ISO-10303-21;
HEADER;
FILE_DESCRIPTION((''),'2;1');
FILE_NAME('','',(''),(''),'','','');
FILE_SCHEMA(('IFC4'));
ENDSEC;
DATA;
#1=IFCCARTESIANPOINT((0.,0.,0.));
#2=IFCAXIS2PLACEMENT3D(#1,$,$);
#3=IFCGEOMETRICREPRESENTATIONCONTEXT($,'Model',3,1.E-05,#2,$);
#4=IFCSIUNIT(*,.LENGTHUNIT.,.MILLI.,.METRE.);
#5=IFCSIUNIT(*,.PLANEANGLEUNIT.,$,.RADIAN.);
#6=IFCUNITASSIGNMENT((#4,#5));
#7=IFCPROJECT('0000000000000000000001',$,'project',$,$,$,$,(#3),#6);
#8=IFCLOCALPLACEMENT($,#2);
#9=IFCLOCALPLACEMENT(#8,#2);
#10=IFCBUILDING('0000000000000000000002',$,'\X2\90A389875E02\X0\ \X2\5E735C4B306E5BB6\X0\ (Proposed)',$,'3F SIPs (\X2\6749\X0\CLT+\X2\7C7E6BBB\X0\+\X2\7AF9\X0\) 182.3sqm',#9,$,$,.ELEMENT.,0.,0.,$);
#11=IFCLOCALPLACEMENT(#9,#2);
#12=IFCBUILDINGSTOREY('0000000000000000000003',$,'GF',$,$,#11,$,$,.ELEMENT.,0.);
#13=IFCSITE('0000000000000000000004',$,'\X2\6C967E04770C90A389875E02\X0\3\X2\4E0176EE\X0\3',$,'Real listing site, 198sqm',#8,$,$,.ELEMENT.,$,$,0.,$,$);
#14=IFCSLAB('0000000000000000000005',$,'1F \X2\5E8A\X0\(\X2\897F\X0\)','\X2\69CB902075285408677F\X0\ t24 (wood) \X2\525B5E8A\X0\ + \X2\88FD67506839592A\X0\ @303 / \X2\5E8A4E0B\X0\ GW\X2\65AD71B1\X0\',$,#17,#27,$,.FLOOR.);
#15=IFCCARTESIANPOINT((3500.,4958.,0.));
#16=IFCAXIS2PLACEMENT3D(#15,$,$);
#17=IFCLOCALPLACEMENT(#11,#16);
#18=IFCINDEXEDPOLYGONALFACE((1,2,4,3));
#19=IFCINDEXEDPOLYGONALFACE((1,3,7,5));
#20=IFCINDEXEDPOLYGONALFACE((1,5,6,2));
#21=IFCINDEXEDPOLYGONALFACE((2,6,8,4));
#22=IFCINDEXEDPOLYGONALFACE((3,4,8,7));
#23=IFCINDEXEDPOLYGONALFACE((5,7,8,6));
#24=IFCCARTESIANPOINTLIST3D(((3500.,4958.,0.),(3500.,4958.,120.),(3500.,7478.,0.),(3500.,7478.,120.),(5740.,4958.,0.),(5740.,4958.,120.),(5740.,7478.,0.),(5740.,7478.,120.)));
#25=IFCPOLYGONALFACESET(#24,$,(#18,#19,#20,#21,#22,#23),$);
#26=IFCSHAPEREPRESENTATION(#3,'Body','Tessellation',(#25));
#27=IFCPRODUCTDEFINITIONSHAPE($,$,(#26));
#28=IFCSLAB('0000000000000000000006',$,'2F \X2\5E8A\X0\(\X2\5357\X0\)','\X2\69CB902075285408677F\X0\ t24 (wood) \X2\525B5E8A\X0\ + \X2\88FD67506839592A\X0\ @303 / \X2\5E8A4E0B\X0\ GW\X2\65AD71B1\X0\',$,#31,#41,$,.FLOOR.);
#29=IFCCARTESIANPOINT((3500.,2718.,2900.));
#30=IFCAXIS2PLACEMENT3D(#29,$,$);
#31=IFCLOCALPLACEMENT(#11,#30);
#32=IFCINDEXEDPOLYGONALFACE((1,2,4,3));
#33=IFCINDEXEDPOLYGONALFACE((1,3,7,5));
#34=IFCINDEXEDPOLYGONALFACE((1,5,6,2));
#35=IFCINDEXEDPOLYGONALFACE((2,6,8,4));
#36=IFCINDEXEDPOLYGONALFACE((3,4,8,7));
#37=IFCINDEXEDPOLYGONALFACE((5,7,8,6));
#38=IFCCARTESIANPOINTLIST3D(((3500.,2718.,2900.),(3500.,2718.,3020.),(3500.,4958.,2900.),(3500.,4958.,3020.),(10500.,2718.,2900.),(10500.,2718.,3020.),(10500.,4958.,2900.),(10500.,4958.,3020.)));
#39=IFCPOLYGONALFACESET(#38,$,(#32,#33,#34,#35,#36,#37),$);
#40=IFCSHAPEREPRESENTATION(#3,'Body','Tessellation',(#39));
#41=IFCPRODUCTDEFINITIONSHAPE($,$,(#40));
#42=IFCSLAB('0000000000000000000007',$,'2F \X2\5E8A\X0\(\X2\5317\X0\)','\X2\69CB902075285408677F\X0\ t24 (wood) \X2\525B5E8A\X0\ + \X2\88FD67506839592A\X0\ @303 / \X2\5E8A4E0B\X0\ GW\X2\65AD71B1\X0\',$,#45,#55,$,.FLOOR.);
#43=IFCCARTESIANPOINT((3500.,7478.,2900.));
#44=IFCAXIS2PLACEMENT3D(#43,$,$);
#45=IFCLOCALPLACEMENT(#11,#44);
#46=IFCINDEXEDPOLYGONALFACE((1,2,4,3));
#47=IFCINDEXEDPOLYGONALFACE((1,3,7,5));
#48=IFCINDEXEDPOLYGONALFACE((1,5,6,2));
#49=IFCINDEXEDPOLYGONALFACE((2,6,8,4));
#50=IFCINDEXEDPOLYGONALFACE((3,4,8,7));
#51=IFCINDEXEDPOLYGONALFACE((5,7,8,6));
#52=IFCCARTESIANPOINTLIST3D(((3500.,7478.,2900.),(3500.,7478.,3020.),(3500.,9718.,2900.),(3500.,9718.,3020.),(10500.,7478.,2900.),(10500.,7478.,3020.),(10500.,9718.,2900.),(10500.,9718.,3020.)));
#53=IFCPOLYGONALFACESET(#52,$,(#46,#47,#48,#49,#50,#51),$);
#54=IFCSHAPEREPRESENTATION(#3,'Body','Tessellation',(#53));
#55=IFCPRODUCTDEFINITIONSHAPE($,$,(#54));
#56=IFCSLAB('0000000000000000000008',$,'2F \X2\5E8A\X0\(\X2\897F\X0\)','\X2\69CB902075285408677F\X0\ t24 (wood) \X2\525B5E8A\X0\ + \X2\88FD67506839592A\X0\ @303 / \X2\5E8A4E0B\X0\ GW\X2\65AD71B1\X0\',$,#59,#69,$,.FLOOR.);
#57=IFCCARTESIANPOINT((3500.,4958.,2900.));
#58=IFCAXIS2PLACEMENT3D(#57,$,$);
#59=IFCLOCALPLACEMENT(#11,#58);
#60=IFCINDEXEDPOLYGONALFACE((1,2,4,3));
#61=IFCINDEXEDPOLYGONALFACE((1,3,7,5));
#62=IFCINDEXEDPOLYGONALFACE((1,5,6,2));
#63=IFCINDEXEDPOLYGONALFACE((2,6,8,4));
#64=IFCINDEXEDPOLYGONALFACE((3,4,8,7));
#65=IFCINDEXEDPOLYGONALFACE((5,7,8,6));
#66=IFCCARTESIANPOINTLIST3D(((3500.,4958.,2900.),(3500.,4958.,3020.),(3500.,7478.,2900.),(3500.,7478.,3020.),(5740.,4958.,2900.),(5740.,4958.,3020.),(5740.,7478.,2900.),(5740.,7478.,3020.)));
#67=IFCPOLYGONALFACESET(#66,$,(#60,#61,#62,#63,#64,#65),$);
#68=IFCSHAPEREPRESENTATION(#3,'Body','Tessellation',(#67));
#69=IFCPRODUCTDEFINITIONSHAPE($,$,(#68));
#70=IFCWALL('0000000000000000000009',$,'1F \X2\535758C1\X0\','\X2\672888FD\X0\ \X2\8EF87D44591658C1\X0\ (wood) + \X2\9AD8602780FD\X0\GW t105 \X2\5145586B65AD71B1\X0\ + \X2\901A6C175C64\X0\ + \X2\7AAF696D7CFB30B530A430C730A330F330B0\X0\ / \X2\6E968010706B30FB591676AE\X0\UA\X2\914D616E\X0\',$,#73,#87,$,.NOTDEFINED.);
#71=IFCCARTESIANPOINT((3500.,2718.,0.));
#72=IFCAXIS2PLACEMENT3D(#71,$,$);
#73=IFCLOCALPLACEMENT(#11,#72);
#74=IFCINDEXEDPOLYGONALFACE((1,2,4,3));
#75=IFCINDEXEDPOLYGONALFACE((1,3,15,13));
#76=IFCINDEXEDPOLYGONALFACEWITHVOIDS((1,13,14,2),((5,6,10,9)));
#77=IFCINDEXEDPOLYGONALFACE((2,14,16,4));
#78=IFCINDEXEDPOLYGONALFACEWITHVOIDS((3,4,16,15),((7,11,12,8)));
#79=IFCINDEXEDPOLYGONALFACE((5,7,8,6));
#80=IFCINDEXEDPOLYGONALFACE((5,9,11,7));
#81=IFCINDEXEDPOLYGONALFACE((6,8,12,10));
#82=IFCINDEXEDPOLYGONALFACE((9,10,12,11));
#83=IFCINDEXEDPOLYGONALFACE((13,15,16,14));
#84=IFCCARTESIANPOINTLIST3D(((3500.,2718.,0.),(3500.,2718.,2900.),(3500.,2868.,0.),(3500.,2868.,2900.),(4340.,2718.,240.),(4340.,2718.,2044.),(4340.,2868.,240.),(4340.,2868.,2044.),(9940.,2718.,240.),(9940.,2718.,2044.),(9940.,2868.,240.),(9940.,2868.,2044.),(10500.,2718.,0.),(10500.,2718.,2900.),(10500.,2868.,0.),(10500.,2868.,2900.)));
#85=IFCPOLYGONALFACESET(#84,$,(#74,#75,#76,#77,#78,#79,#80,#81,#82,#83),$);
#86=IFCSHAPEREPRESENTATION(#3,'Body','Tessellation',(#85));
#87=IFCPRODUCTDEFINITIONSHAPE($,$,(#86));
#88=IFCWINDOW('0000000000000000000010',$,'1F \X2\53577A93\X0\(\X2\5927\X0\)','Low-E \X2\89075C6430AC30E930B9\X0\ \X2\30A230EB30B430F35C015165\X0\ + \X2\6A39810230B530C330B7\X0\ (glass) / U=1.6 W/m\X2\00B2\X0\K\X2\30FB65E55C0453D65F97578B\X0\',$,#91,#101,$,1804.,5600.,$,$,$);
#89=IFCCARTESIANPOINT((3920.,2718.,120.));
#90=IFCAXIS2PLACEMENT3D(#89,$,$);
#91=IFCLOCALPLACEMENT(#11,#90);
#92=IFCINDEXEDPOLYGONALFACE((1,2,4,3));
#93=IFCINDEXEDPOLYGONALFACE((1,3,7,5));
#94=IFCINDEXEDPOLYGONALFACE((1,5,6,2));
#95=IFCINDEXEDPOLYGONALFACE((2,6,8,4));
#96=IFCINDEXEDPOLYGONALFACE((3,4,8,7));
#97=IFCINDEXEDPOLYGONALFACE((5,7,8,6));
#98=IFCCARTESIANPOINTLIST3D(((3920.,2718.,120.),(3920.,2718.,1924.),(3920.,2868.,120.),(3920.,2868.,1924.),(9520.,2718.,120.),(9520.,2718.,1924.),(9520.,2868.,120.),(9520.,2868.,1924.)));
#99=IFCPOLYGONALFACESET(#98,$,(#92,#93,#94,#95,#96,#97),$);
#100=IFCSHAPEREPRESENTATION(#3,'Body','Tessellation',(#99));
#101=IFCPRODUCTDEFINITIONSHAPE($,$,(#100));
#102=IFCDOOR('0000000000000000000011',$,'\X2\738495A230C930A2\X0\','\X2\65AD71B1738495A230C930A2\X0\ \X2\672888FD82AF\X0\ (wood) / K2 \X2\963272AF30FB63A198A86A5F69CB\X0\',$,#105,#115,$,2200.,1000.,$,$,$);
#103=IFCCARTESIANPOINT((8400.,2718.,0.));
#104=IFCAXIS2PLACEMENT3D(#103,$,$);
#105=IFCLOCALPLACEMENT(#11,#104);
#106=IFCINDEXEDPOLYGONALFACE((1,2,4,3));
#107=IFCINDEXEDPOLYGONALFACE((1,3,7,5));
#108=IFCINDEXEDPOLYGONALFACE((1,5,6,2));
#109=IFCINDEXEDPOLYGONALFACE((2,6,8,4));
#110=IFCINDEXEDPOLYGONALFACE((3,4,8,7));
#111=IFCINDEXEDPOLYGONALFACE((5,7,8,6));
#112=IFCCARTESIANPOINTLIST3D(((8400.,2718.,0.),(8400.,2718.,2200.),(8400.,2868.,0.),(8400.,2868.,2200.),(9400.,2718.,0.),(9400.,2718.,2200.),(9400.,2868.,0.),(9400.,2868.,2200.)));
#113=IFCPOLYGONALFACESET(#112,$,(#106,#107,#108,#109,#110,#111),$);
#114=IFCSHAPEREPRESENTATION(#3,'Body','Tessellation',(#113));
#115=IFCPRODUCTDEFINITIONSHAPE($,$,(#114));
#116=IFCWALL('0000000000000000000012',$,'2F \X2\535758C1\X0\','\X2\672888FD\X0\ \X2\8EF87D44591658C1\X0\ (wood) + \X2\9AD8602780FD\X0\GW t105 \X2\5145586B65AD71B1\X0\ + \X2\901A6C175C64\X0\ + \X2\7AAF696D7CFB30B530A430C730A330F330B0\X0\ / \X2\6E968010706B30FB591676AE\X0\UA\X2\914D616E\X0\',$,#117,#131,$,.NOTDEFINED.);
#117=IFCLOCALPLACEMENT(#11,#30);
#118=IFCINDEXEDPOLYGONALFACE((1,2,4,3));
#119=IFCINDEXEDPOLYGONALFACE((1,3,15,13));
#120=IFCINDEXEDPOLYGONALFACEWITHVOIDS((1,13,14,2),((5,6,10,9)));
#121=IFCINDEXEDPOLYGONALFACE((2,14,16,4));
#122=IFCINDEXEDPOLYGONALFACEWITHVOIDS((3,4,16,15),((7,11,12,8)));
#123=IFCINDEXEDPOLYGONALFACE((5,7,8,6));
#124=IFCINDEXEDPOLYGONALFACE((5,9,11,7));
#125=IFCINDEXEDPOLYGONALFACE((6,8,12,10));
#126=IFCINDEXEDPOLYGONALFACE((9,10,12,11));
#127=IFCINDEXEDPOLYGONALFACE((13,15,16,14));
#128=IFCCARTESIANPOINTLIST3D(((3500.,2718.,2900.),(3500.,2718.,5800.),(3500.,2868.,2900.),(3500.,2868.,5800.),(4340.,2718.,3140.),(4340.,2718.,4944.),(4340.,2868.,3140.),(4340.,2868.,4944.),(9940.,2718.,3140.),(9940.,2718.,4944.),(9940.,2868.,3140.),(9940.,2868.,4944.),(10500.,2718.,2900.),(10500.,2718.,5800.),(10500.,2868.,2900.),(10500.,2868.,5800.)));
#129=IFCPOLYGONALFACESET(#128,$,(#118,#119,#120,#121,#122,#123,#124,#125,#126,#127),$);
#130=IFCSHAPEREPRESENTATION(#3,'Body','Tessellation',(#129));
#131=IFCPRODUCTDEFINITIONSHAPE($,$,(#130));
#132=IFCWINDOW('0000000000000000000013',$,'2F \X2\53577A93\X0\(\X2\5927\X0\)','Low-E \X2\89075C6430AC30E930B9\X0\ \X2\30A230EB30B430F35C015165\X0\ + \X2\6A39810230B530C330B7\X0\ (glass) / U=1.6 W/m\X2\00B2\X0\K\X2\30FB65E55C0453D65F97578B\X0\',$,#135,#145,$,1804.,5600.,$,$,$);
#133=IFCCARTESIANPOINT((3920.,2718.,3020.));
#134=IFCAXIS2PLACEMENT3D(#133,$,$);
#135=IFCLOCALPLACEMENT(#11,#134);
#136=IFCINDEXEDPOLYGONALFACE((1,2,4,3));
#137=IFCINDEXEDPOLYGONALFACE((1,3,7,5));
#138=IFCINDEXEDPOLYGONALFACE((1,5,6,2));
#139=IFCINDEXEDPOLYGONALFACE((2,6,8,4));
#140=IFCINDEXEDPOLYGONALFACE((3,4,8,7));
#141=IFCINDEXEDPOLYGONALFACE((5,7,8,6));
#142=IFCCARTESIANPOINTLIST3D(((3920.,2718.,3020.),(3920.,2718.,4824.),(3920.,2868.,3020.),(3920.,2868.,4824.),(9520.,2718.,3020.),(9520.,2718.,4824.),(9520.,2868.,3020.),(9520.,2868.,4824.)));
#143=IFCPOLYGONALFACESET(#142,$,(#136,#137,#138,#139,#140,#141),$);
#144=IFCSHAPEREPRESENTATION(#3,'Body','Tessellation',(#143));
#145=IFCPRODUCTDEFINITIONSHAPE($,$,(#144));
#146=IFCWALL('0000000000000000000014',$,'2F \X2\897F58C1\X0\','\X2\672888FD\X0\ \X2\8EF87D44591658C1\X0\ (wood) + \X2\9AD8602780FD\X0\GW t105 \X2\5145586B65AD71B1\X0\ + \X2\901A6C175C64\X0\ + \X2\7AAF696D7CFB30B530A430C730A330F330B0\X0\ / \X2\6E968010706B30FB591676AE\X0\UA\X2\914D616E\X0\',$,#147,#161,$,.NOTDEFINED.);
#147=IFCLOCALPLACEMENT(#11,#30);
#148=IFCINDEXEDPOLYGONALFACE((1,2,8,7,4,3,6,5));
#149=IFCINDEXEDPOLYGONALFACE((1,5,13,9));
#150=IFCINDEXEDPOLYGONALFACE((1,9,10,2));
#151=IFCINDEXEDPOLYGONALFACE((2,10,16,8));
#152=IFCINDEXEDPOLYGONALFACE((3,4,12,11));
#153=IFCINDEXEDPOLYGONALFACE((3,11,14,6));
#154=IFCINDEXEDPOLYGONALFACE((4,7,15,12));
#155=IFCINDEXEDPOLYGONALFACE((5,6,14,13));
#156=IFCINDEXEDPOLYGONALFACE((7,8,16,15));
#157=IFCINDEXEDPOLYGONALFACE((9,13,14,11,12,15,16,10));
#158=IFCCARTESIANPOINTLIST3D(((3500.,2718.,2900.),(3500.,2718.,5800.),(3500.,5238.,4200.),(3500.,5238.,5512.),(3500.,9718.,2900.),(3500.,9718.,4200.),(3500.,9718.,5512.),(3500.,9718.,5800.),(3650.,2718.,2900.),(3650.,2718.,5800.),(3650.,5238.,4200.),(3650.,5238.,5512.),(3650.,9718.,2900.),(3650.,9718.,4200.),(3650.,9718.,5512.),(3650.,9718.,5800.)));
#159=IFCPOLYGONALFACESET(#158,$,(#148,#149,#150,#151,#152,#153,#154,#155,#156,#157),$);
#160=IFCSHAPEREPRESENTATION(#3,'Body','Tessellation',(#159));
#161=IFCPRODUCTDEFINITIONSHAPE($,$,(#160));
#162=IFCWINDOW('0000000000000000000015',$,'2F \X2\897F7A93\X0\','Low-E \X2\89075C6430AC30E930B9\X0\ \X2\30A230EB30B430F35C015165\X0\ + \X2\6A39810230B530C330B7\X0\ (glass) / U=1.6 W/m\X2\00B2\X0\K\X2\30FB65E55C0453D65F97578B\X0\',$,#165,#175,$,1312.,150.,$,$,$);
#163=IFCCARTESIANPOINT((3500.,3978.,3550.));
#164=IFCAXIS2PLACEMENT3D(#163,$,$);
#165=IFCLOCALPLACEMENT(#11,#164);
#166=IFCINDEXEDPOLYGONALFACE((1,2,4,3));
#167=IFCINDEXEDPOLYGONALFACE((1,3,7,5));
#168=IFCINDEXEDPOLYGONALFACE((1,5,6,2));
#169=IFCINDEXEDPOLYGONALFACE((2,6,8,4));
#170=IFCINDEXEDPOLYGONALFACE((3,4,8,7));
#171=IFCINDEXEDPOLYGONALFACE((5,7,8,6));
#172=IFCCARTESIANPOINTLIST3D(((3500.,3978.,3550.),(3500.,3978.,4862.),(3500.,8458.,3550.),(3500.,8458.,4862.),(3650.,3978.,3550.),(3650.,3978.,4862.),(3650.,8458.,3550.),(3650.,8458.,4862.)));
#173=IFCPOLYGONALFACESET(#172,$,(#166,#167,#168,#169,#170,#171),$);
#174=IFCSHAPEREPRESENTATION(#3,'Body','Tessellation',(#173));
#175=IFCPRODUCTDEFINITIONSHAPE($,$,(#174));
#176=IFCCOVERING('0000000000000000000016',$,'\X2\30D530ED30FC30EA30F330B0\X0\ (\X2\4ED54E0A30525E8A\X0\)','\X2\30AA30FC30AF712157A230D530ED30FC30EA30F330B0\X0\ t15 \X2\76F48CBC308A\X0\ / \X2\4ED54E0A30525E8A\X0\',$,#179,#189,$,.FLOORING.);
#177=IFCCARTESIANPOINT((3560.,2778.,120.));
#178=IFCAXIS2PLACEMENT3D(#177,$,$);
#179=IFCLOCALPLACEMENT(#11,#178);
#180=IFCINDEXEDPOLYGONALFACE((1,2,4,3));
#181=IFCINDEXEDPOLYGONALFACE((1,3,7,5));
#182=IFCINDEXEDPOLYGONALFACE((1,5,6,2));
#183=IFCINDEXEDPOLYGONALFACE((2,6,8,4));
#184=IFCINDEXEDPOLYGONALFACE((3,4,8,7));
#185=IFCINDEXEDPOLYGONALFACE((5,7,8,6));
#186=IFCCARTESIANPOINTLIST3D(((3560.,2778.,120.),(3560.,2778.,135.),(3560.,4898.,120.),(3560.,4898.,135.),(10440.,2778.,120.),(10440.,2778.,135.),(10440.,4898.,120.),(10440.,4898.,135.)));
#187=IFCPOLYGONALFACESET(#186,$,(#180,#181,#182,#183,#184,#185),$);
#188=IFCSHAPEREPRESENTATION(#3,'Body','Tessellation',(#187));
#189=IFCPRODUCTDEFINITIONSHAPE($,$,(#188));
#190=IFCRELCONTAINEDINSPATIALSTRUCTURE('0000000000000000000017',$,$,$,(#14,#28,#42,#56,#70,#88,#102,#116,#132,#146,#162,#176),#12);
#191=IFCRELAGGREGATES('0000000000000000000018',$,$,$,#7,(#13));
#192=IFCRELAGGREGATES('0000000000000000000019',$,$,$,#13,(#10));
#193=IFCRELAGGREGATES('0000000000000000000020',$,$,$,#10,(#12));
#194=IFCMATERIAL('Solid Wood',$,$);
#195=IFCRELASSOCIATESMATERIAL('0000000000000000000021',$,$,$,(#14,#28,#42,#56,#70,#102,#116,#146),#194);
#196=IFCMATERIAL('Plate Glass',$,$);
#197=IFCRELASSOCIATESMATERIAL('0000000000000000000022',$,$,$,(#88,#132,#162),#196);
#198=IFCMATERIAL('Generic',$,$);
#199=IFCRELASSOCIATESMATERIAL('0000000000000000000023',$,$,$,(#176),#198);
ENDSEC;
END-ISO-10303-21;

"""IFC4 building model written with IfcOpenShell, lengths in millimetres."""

from ifc_helpers import new_model, si_unit, frame, frame_2d, origin, place, context, project, spatial, rectangle, extrude, material, element, fill, save


model = new_model("IFC4")

# Units and contexts
model_context = context("Model", 3, precision=1e-05, world=origin())
ifc_project = project(units=[si_unit("LENGTHUNIT", "METRE", prefix="MILLI"), si_unit("PLANEANGLEUNIT", "RADIAN")], contexts=[model_context])

# Site, building, storey
site_placement = place(None, origin())
site = spatial("IfcSite", under=ifc_project, at=site_placement, Name="沖縄県那覇市3丁目3", ObjectType="Real listing site, 198sqm", CompositionType="ELEMENT", RefElevation=0.0)
building_placement = place(site_placement, origin())
building = spatial("IfcBuilding", under=site, at=building_placement, Name="那覇市 平屋の家 (Proposed)", ObjectType="3F SIPs (杉CLT+籾殻+竹) 182.3sqm", CompositionType="ELEMENT", ElevationOfRefHeight=0.0, ElevationOfTerrain=0.0)
storey_placement = place(building_placement, origin())
storey = spatial("IfcBuildingStorey", under=building, at=storey_placement, Name="GF", CompositionType="ELEMENT", Elevation=0.0)

# Slabs
ifc_material_1 = material(Name="Solid Wood")
slab_1_placement = place(storey_placement, frame((3500.0, 4958.0, 0.0)))
element("IfcSlab", 1, at=slab_1_placement, inside=storey, material=ifc_material_1, Name="1F 床(西)", Description="構造用合板 t24 (wood) 剛床 + 製材根太 @303 / 床下 GW断熱", PredefinedType="FLOOR", context=model_context, shape_type="SweptSolid", body=[
    extrude(rectangle(XDim=2240.0, YDim=2520.0, at=frame_2d((1120.0, 1260.0))), frame((3500.0, 4958.0, 0.0)), (0.0, 0.0, 1.0), 120.0),
])
slab_2_placement = place(storey_placement, frame((3500.0, 2718.0, 2900.0)))
element("IfcSlab", 2, at=slab_2_placement, inside=storey, material=ifc_material_1, Name="2F 床(南)", Description="構造用合板 t24 (wood) 剛床 + 製材根太 @303 / 床下 GW断熱", PredefinedType="FLOOR", context=model_context, shape_type="SweptSolid", body=[
    extrude(rectangle(XDim=7000.0, YDim=2240.0, at=frame_2d((3500.0, 1120.0))), frame((3500.0, 2718.0, 2900.0)), (0.0, 0.0, 1.0), 120.0),
])
slab_3_placement = place(storey_placement, frame((3500.0, 7478.0, 2900.0)))
element("IfcSlab", 3, at=slab_3_placement, inside=storey, material=ifc_material_1, Name="2F 床(北)", Description="構造用合板 t24 (wood) 剛床 + 製材根太 @303 / 床下 GW断熱", PredefinedType="FLOOR", context=model_context, shape_type="SweptSolid", body=[
    extrude(rectangle(XDim=7000.0, YDim=2240.0, at=frame_2d((3500.0, 1120.0))), frame((3500.0, 7478.0, 2900.0)), (0.0, 0.0, 1.0), 120.0),
])
slab_4_placement = place(storey_placement, frame((3500.0, 4958.0, 2900.0)))
element("IfcSlab", 4, at=slab_4_placement, inside=storey, material=ifc_material_1, Name="2F 床(西)", Description="構造用合板 t24 (wood) 剛床 + 製材根太 @303 / 床下 GW断熱", PredefinedType="FLOOR", context=model_context, shape_type="SweptSolid", body=[
    extrude(rectangle(XDim=2240.0, YDim=2520.0, at=frame_2d((1120.0, 1260.0))), frame((3500.0, 4958.0, 2900.0)), (0.0, 0.0, 1.0), 120.0),
])

# Wall, openings, window, door
wall_1_placement = place(storey_placement, frame((3500.0, 2718.0, 0.0)))
wall_1 = element("IfcWall", 5, at=wall_1_placement, inside=storey, material=ifc_material_1, Name="1F 南壁", Description="木製 軸組外壁 (wood) + 高性能GW t105 充填断熱 + 通気層 + 窯業系サイディング / 準耐火・外皮UA配慮", PredefinedType="NOTDEFINED", context=model_context, shape_type="SweptSolid", body=[
    extrude(rectangle(XDim=7000.0, YDim=150.0, at=frame_2d((3500.0, 75.0))), frame((3500.0, 2718.0, 0.0)), (0.0, 0.0, 1.0), 2900.0),
])
opening_1_placement = place(storey_placement, frame((3920.0, 2718.0, 120.0)))
opening_1 = element("IfcOpeningElement", 6, at=opening_1_placement, cuts=wall_1, PredefinedType="NOTDEFINED", context=model_context, shape_type="SweptSolid", body=[
    extrude(rectangle(XDim=5600.0, YDim=150.0, at=frame_2d((2800.0, 75.0))), frame((3920.0, 2718.0, 120.0)), (0.0, 0.0, 1.0), 1804.0),
])
opening_2_placement = place(storey_placement, frame((8400.0, 2718.0, 0.0)))
opening_2 = element("IfcOpeningElement", 7, at=opening_2_placement, cuts=wall_1, PredefinedType="NOTDEFINED", context=model_context, shape_type="SweptSolid", body=[
    extrude(rectangle(XDim=1000.0, YDim=150.0, at=frame_2d((500.0, 75.0))), frame((8400.0, 2718.0, 0.0)), (0.0, 0.0, 1.0), 2200.0),
])
ifc_material_2 = material(Name="Plate Glass")
window_1_placement = place(storey_placement, frame((3920.0, 2718.0, 120.0)))
window_1 = element("IfcWindow", 8, at=window_1_placement, inside=storey, material=ifc_material_2, Name="1F 南窓(大)", Description="Low-E 複層ガラス アルゴン封入 + 樹脂サッシ (glass) / U=1.6 W/m²K・日射取得型", OverallHeight=1804.0, OverallWidth=5600.0, context=model_context, shape_type="SweptSolid", body=[
    extrude(rectangle(XDim=5600.0, YDim=150.0, at=frame_2d((2800.0, 75.0))), frame((3920.0, 2718.0, 120.0)), (0.0, 0.0, 1.0), 1804.0),
])
fill(opening_1, window_1)
door_placement = place(storey_placement, frame((8400.0, 2718.0, 0.0)))
door = element("IfcDoor", 9, at=door_placement, inside=storey, material=ifc_material_1, Name="玄関ドア", Description="断熱玄関ドア 木製芯 (wood) / K2 防犯・採風機構", OverallHeight=2200.0, OverallWidth=1000.0, context=model_context, shape_type="SweptSolid", body=[
    extrude(rectangle(XDim=1000.0, YDim=150.0, at=frame_2d((500.0, 75.0))), frame((8400.0, 2718.0, 0.0)), (0.0, 0.0, 1.0), 2200.0),
])
fill(opening_2, door)

# Wall, opening, window
wall_2_placement = place(storey_placement, frame((3500.0, 2718.0, 2900.0)))
wall_2 = element("IfcWall", 10, at=wall_2_placement, inside=storey, material=ifc_material_1, Name="2F 南壁", Description="木製 軸組外壁 (wood) + 高性能GW t105 充填断熱 + 通気層 + 窯業系サイディング / 準耐火・外皮UA配慮", PredefinedType="NOTDEFINED", context=model_context, shape_type="SweptSolid", body=[
    extrude(rectangle(XDim=7000.0, YDim=150.0, at=frame_2d((3500.0, 75.0))), frame((3500.0, 2718.0, 2900.0)), (0.0, 0.0, 1.0), 2900.0),
])
opening_3_placement = place(storey_placement, frame((3920.0, 2718.0, 3020.0)))
opening_3 = element("IfcOpeningElement", 11, at=opening_3_placement, cuts=wall_2, PredefinedType="NOTDEFINED", context=model_context, shape_type="SweptSolid", body=[
    extrude(rectangle(XDim=5600.0, YDim=150.0, at=frame_2d((2800.0, 75.0))), frame((3920.0, 2718.0, 3020.0)), (0.0, 0.0, 1.0), 1804.0),
])
window_2_placement = place(storey_placement, frame((3920.0, 2718.0, 3020.0)))
window_2 = element("IfcWindow", 12, at=window_2_placement, inside=storey, material=ifc_material_2, Name="2F 南窓(大)", Description="Low-E 複層ガラス アルゴン封入 + 樹脂サッシ (glass) / U=1.6 W/m²K・日射取得型", OverallHeight=1804.0, OverallWidth=5600.0, context=model_context, shape_type="SweptSolid", body=[
    extrude(rectangle(XDim=5600.0, YDim=150.0, at=frame_2d((2800.0, 75.0))), frame((3920.0, 2718.0, 3020.0)), (0.0, 0.0, 1.0), 1804.0),
])
fill(opening_3, window_2)

# Wall, opening, window
wall_3_placement = place(storey_placement, frame((3500.0, 2718.0, 2900.0)))
wall_3 = element("IfcWall", 13, at=wall_3_placement, inside=storey, material=ifc_material_1, Name="2F 西壁", Description="木製 軸組外壁 (wood) + 高性能GW t105 充填断熱 + 通気層 + 窯業系サイディング / 準耐火・外皮UA配慮", PredefinedType="NOTDEFINED", context=model_context, shape_type="SweptSolid", body=[
    extrude(rectangle(XDim=150.0, YDim=7000.0, at=frame_2d((75.0, 3500.0))), frame((3500.0, 2718.0, 2900.0)), (0.0, 0.0, 1.0), 2900.0),
])
opening_4_placement = place(storey_placement, frame((3500.0, 3978.0, 3550.0)))
opening_4 = element("IfcOpeningElement", 14, at=opening_4_placement, cuts=wall_3, PredefinedType="NOTDEFINED", context=model_context, shape_type="SweptSolid", body=[
    extrude(rectangle(XDim=150.0, YDim=4480.0, at=frame_2d((75.0, 2240.0))), frame((3500.0, 3978.0, 3550.0)), (0.0, 0.0, 1.0), 1312.0),
])
window_3_placement = place(storey_placement, frame((3500.0, 3978.0, 3550.0)))
window_3 = element("IfcWindow", 15, at=window_3_placement, inside=storey, material=ifc_material_2, Name="2F 西窓", Description="Low-E 複層ガラス アルゴン封入 + 樹脂サッシ (glass) / U=1.6 W/m²K・日射取得型", OverallHeight=1312.0, OverallWidth=150.0, context=model_context, shape_type="SweptSolid", body=[
    extrude(rectangle(XDim=150.0, YDim=4480.0, at=frame_2d((75.0, 2240.0))), frame((3500.0, 3978.0, 3550.0)), (0.0, 0.0, 1.0), 1312.0),
])
fill(opening_4, window_3)

# Covering
ifc_material_3 = material(Name="Generic")
covering_1_placement = place(storey_placement, frame((3560.0, 2778.0, 120.0)))
element("IfcCovering", 16, at=covering_1_placement, inside=storey, material=ifc_material_3, Name="フローリング (仕上げ床)", Description="オーク無垢フローリング t15 直貼り / 仕上げ床", PredefinedType="FLOORING", context=model_context, shape_type="SweptSolid", body=[
    extrude(rectangle(XDim=6880.0, YDim=2120.0, at=frame_2d((3440.0, 1060.0))), frame((3560.0, 2778.0, 120.0)), (0.0, 0.0, 1.0), 15.0),
])

save(model, "model.ifc")
